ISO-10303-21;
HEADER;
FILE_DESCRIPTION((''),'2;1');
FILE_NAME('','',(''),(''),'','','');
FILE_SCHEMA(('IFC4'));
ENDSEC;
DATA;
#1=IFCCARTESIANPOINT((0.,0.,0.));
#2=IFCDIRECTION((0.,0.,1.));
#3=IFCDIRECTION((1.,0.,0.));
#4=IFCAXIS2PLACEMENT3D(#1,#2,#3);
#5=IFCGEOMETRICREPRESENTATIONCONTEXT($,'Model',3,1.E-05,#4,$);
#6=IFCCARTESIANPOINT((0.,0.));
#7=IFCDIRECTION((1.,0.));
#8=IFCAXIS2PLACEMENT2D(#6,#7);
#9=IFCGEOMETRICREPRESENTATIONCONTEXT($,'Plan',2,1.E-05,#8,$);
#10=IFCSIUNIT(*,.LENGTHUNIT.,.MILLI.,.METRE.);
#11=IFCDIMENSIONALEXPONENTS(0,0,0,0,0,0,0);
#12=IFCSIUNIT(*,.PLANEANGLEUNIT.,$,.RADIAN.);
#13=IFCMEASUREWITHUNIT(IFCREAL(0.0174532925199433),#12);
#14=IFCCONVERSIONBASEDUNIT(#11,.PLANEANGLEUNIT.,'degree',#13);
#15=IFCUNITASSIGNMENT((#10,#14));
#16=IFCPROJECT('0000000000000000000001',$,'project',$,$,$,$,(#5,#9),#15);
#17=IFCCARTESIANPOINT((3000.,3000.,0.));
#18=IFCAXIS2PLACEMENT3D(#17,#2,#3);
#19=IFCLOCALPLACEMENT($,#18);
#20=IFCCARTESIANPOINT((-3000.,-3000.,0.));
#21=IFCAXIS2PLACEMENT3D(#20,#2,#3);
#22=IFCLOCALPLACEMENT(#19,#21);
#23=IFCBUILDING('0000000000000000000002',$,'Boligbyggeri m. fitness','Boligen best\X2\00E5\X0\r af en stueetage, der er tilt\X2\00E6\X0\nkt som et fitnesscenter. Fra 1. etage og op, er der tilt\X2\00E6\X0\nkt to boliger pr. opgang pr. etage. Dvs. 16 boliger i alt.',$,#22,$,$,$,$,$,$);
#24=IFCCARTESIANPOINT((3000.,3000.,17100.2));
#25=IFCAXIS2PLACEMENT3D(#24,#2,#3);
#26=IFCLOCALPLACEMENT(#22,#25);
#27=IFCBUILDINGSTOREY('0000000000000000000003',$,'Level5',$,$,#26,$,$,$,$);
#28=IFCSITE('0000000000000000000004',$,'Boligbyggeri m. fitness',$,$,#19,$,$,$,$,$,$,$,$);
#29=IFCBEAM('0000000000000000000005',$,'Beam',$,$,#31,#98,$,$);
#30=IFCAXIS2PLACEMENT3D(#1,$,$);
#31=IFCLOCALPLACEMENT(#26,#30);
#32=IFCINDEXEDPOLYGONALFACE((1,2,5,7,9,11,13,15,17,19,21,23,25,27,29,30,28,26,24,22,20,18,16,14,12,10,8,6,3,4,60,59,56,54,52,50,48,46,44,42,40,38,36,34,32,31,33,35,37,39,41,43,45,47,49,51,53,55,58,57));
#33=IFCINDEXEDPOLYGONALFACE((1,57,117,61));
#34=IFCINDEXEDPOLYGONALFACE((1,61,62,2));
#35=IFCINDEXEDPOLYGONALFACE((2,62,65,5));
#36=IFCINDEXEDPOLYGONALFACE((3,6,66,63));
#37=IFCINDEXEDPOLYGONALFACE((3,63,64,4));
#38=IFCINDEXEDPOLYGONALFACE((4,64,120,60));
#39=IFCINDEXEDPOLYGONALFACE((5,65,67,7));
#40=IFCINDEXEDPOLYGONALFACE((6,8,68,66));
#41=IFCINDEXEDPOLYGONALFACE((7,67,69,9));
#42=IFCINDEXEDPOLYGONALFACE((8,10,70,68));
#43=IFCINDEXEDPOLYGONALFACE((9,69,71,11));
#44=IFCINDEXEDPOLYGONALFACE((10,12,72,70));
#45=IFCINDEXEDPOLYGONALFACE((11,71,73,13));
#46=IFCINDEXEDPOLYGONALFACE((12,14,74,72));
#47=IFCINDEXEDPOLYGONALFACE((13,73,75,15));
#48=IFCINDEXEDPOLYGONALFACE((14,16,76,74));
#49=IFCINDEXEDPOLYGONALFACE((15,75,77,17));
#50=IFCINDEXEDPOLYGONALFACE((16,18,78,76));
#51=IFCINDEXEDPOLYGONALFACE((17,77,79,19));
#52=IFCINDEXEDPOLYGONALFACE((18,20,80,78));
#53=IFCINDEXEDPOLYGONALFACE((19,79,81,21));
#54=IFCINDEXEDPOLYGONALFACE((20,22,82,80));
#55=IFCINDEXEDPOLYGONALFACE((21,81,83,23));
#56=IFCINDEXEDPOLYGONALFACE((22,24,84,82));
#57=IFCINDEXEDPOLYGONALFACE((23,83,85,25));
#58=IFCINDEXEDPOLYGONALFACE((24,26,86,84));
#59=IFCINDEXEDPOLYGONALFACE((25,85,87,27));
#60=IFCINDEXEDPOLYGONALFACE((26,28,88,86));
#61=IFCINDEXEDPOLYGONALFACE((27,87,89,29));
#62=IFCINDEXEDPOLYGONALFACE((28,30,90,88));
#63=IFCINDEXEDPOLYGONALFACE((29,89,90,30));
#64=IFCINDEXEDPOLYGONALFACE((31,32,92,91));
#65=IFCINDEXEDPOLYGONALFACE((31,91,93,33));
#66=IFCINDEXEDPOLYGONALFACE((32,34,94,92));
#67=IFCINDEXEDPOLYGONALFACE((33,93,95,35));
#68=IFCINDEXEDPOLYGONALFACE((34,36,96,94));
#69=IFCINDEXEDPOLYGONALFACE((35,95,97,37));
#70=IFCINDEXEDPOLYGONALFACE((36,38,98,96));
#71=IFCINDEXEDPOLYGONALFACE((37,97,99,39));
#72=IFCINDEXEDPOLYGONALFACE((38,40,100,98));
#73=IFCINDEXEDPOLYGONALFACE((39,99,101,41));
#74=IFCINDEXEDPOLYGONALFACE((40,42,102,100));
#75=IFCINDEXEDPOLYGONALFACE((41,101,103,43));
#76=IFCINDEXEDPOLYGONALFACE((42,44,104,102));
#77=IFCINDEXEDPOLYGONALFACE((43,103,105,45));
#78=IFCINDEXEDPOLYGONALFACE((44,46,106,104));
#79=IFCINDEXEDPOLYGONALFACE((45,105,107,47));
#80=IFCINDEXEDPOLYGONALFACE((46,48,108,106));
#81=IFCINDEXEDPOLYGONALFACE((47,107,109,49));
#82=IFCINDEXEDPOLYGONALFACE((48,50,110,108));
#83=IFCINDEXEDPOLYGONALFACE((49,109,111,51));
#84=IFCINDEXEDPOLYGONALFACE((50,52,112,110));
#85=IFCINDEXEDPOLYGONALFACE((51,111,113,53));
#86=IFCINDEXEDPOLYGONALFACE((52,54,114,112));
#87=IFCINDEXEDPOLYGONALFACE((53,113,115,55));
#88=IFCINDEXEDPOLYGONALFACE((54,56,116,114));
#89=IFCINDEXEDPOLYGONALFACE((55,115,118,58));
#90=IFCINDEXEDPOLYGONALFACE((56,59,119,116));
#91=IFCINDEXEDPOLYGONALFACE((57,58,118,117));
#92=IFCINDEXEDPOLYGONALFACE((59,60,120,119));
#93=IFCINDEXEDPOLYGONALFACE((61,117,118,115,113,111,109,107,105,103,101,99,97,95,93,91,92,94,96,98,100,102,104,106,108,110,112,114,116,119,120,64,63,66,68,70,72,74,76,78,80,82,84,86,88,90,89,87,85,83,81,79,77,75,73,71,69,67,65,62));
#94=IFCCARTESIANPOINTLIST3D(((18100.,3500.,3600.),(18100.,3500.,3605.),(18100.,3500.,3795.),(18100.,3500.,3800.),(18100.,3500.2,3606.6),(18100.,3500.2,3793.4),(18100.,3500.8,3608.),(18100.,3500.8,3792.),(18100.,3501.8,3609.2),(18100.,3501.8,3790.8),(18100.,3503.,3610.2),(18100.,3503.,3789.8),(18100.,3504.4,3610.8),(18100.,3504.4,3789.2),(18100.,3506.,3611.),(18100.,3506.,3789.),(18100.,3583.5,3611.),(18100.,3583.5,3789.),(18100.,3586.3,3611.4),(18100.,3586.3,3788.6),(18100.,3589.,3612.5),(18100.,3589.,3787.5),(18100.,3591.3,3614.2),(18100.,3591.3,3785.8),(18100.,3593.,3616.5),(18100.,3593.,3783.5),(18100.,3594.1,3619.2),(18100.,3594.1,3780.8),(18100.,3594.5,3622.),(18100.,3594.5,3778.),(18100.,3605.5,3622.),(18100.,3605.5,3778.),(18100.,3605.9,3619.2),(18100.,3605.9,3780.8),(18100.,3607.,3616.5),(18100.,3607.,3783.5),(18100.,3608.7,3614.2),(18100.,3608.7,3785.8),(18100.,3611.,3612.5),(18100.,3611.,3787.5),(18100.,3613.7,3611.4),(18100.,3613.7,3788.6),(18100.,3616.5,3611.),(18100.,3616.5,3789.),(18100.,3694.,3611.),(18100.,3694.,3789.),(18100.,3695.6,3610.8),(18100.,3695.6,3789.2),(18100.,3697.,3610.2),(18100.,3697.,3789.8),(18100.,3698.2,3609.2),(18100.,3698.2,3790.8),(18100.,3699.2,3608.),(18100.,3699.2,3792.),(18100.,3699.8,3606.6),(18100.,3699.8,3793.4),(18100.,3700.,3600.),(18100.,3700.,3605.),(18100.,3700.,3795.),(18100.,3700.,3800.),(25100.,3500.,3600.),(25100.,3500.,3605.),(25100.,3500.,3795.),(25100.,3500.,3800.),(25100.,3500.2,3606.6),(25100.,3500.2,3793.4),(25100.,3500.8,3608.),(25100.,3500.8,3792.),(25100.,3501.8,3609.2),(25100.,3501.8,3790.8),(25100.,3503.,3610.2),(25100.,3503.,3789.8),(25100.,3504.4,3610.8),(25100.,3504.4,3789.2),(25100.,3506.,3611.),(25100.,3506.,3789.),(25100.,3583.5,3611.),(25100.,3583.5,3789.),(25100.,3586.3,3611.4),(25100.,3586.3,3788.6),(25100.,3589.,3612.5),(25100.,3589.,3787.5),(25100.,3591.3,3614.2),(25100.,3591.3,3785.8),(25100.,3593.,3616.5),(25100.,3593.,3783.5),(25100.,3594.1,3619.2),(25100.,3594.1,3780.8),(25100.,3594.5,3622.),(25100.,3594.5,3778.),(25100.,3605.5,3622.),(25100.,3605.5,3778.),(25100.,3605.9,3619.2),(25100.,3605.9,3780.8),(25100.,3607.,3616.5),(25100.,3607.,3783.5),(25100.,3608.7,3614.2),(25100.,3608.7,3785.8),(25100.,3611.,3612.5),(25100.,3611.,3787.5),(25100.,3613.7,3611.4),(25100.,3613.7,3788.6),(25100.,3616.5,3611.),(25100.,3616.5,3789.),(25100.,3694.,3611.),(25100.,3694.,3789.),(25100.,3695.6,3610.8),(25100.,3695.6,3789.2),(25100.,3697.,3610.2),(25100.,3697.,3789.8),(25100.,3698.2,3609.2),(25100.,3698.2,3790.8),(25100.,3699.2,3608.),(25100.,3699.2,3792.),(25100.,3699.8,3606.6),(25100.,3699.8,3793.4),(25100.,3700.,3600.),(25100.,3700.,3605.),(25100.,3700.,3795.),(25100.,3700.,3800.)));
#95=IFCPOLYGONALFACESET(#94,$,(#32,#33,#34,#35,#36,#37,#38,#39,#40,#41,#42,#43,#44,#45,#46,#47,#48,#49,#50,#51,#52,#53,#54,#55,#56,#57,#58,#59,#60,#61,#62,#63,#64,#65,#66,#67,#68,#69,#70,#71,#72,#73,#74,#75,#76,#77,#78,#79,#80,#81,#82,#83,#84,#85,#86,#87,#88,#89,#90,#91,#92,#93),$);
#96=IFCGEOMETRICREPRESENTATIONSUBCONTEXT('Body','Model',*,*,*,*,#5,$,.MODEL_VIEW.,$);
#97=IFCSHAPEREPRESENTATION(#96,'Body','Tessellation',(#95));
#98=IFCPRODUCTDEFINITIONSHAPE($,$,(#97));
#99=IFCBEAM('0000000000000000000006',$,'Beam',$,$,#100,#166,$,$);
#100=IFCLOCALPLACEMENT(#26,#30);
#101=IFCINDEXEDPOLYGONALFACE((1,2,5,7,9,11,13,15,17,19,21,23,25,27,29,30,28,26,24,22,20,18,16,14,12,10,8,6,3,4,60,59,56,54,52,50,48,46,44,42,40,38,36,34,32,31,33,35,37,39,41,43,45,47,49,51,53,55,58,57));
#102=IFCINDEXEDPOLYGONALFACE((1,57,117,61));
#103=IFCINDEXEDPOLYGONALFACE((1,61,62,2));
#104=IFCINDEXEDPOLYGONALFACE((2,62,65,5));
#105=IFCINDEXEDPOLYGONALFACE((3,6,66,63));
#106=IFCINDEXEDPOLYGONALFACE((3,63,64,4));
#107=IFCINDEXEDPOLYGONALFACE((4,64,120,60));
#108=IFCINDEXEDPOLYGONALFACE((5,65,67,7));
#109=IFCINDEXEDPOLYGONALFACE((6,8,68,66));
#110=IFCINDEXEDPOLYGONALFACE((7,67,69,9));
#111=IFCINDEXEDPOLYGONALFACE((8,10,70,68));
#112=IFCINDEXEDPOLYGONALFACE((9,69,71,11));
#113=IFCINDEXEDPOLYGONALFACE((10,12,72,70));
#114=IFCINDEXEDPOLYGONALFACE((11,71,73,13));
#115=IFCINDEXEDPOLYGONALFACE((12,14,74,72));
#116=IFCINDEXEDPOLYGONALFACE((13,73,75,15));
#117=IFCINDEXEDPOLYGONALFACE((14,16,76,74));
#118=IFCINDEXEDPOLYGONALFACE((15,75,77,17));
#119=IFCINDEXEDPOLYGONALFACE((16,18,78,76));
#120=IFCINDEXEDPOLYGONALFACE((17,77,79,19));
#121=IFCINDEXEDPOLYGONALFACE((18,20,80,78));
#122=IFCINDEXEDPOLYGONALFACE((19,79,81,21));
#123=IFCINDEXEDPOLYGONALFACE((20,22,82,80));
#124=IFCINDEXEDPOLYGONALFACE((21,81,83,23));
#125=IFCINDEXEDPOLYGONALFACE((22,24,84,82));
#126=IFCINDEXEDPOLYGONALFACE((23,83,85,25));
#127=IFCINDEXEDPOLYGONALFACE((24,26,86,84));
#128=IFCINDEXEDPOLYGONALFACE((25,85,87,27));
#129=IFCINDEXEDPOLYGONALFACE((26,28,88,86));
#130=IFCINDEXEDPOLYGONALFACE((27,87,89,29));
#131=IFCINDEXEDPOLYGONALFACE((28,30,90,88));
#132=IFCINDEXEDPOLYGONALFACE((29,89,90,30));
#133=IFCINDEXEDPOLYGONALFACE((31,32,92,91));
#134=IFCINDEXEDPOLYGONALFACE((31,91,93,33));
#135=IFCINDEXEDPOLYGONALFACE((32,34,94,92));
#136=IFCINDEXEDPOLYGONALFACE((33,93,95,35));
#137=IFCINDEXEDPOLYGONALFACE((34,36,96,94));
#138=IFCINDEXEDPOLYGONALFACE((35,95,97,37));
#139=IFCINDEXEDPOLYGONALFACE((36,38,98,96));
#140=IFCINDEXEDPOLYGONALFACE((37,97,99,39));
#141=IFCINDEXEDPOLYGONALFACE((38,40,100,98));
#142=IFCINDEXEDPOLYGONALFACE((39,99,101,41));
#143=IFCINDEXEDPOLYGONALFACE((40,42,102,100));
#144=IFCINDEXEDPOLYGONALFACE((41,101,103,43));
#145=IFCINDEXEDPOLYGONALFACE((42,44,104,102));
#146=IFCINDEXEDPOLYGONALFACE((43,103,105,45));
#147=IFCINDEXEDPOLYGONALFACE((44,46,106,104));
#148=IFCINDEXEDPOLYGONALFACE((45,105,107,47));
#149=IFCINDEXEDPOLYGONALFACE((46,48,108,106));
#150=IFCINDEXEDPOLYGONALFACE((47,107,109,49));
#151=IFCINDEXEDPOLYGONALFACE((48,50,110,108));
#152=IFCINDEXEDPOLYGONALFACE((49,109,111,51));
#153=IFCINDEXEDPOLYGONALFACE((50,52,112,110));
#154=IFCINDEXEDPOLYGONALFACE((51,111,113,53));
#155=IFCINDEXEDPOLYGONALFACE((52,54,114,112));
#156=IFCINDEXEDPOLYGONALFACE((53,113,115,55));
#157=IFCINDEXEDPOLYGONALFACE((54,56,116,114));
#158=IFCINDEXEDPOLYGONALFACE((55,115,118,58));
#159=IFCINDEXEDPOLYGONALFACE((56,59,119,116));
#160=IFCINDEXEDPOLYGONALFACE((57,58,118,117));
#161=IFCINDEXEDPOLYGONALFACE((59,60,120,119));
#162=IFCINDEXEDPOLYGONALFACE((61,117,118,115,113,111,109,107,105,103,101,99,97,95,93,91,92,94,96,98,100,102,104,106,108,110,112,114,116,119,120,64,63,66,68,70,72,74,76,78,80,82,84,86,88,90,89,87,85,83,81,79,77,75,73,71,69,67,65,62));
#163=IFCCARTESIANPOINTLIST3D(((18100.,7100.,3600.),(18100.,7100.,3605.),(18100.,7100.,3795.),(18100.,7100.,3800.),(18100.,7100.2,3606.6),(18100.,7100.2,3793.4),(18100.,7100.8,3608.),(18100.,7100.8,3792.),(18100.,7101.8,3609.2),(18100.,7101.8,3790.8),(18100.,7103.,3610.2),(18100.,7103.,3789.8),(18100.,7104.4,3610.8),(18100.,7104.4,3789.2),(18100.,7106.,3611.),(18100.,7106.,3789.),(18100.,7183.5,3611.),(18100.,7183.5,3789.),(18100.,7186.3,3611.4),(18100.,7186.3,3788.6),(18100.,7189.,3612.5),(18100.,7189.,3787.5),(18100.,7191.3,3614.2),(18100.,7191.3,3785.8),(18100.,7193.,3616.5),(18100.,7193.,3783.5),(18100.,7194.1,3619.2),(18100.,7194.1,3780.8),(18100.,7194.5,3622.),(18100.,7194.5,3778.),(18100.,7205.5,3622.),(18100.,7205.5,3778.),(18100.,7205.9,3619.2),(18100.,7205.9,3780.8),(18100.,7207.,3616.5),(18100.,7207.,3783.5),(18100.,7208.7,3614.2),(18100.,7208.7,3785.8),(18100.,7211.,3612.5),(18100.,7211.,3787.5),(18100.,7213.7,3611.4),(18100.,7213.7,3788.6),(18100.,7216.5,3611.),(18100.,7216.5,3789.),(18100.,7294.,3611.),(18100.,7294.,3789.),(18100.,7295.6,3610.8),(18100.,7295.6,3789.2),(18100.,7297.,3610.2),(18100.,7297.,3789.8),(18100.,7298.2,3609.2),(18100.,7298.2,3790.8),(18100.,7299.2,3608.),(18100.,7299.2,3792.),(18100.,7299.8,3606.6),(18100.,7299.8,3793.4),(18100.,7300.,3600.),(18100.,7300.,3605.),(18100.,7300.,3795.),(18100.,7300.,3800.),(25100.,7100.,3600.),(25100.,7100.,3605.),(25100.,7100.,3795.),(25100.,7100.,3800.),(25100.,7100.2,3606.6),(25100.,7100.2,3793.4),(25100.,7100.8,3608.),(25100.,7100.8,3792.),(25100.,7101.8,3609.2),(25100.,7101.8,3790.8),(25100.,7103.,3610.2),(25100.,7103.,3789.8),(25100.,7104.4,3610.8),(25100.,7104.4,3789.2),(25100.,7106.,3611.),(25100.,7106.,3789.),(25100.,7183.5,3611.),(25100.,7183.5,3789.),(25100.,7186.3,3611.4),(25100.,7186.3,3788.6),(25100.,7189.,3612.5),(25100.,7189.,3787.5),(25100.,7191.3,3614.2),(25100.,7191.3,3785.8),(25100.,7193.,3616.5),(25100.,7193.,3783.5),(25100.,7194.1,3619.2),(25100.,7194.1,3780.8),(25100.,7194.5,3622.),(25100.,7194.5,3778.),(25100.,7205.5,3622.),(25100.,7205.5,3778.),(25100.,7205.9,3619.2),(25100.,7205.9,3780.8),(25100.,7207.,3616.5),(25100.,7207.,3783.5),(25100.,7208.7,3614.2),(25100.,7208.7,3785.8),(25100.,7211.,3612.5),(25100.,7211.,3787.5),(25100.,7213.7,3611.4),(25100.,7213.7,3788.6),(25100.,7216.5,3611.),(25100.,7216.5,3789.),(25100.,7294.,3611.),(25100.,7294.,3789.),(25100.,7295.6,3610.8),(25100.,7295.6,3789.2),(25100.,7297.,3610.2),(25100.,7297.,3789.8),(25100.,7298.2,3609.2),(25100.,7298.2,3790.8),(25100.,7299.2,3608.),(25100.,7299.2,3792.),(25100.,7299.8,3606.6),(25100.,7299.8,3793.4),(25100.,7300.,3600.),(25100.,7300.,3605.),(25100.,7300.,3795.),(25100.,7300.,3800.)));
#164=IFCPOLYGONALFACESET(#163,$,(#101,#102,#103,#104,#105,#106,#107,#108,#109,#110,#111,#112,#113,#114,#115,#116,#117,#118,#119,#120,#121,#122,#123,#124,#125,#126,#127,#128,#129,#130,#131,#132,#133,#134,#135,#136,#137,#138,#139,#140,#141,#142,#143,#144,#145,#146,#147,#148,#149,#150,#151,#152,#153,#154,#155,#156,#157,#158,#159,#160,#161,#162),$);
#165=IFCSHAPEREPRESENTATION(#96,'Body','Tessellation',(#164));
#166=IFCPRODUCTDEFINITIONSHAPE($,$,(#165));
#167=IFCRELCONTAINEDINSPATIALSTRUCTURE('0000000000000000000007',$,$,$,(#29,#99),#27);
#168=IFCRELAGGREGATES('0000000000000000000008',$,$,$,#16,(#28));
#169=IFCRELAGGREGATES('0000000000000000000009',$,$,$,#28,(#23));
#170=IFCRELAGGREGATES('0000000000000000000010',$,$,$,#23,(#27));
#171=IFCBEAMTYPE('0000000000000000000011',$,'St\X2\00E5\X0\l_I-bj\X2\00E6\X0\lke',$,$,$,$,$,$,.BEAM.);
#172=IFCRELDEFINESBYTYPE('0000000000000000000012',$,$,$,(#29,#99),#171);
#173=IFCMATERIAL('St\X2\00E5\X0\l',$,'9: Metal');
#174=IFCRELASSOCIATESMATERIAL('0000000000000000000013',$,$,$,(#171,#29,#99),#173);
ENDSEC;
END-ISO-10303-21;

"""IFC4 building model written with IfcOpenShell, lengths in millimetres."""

from ifc_helpers import new_model, entity, si_unit, converted_unit, frame, origin_with_axes, origin_2d_with_axis, place, context, subcontext, project, spatial, i_section, extrude, material, material_profile, profile_set, profile_usage, type_object, element, save


model = new_model("IFC4")

# Units and contexts
model_context = context("Model", 3, precision=1e-05, world=origin_with_axes())
plan_context = context("Plan", 2, precision=1e-05, world=origin_2d_with_axis())
body_context = subcontext(model_context, "Body", "Model", "MODEL_VIEW")
ifc_project = project(units=[si_unit("LENGTHUNIT", "METRE", prefix="MILLI"), converted_unit("PLANEANGLEUNIT", "degree", entity("IfcReal", 0.0174532925199433), si_unit("PLANEANGLEUNIT", "RADIAN"), dimensions=[0, 0, 0, 0, 0, 0, 0])], contexts=[model_context, plan_context])

# Site, building, storey
site_placement = place(None, frame((3000.0, 3000.0, 0.0), z_axis=(0.0, 0.0, 1.0), x_axis=(1.0, 0.0, 0.0)))
site = spatial("IfcSite", under=ifc_project, at=site_placement, Name="Boligbyggeri m. fitness")
building_placement = place(site_placement, frame((-3000.0, -3000.0, 0.0), z_axis=(0.0, 0.0, 1.0), x_axis=(1.0, 0.0, 0.0)))
building = spatial("IfcBuilding", under=site, at=building_placement, Name="Boligbyggeri m. fitness", Description="Boligen består af en stueetage, der er tiltænkt som et fitnesscenter. Fra 1. etage og op, er der tiltænkt to boliger pr. opgang pr. etage. Dvs. 16 boliger i alt.")
storey_placement = place(building_placement, frame((3000.0, 3000.0, 17100.2), z_axis=(0.0, 0.0, 1.0), x_axis=(1.0, 0.0, 0.0)))
storey = spatial("IfcBuildingStorey", under=building, at=storey_placement, Name="Level5")

# Beams
ifc_material_1 = material(Name="Stål", Category="9: Metal")
ifc_material_profile_1 = material_profile(ifc_material_1, i_section(OverallWidth=200.0, OverallDepth=200.0, WebThickness=11.0, FlangeThickness=11.0, FilletRadius=11.0, FlangeEdgeRadius=6.0), Name="Stål", Category="9: Metal")
ifc_profile_set_1 = profile_set([ifc_material_profile_1], Name="NY_I-Profil")
beam_type = type_object("IfcBeamType", Name="Stål_I-bjælke", PredefinedType="BEAM", material=ifc_profile_set_1)
ifc_profile_usage_1 = profile_usage(ifc_profile_set_1, cardinal=7)
beam_1_placement = place(storey_placement, frame((18100.0, 3700.0, 3800.0), z_axis=(1.0, 0.0, 0.0), x_axis=(0.0, 1.0, 0.0)))
element("IfcBeam", 1, at=beam_1_placement, inside=storey, type_object=beam_type, material=ifc_profile_usage_1, Name="Beam", context=body_context, shape_type="SweptSolid", body=[
    extrude(i_section(OverallWidth=200.0, OverallDepth=200.0, WebThickness=11.0, FlangeThickness=11.0, FilletRadius=11.0, FlangeEdgeRadius=6.0), frame((-100.0, -100.0, 0.0), z_axis=(0.0, 0.0, 1.0), x_axis=(1.0, 0.0, 0.0)), (0.0, 0.0, 1.0), 7000.0),
])
ifc_profile_usage_2 = profile_usage(ifc_profile_set_1, cardinal=7)
beam_2_placement = place(storey_placement, frame((18100.0, 7300.0, 3800.0), z_axis=(1.0, 0.0, 0.0), x_axis=(0.0, 1.0, 0.0)))
element("IfcBeam", 2, at=beam_2_placement, inside=storey, type_object=beam_type, material=ifc_profile_usage_2, Name="Beam", context=body_context, shape_type="SweptSolid", body=[
    extrude(i_section(OverallWidth=200.0, OverallDepth=200.0, WebThickness=11.0, FlangeThickness=11.0, FilletRadius=11.0, FlangeEdgeRadius=6.0), frame((-100.0, -100.0, 0.0), z_axis=(0.0, 0.0, 1.0), x_axis=(1.0, 0.0, 0.0)), (0.0, 0.0, 1.0), 7000.0),
])

save(model, "model.ifc")
